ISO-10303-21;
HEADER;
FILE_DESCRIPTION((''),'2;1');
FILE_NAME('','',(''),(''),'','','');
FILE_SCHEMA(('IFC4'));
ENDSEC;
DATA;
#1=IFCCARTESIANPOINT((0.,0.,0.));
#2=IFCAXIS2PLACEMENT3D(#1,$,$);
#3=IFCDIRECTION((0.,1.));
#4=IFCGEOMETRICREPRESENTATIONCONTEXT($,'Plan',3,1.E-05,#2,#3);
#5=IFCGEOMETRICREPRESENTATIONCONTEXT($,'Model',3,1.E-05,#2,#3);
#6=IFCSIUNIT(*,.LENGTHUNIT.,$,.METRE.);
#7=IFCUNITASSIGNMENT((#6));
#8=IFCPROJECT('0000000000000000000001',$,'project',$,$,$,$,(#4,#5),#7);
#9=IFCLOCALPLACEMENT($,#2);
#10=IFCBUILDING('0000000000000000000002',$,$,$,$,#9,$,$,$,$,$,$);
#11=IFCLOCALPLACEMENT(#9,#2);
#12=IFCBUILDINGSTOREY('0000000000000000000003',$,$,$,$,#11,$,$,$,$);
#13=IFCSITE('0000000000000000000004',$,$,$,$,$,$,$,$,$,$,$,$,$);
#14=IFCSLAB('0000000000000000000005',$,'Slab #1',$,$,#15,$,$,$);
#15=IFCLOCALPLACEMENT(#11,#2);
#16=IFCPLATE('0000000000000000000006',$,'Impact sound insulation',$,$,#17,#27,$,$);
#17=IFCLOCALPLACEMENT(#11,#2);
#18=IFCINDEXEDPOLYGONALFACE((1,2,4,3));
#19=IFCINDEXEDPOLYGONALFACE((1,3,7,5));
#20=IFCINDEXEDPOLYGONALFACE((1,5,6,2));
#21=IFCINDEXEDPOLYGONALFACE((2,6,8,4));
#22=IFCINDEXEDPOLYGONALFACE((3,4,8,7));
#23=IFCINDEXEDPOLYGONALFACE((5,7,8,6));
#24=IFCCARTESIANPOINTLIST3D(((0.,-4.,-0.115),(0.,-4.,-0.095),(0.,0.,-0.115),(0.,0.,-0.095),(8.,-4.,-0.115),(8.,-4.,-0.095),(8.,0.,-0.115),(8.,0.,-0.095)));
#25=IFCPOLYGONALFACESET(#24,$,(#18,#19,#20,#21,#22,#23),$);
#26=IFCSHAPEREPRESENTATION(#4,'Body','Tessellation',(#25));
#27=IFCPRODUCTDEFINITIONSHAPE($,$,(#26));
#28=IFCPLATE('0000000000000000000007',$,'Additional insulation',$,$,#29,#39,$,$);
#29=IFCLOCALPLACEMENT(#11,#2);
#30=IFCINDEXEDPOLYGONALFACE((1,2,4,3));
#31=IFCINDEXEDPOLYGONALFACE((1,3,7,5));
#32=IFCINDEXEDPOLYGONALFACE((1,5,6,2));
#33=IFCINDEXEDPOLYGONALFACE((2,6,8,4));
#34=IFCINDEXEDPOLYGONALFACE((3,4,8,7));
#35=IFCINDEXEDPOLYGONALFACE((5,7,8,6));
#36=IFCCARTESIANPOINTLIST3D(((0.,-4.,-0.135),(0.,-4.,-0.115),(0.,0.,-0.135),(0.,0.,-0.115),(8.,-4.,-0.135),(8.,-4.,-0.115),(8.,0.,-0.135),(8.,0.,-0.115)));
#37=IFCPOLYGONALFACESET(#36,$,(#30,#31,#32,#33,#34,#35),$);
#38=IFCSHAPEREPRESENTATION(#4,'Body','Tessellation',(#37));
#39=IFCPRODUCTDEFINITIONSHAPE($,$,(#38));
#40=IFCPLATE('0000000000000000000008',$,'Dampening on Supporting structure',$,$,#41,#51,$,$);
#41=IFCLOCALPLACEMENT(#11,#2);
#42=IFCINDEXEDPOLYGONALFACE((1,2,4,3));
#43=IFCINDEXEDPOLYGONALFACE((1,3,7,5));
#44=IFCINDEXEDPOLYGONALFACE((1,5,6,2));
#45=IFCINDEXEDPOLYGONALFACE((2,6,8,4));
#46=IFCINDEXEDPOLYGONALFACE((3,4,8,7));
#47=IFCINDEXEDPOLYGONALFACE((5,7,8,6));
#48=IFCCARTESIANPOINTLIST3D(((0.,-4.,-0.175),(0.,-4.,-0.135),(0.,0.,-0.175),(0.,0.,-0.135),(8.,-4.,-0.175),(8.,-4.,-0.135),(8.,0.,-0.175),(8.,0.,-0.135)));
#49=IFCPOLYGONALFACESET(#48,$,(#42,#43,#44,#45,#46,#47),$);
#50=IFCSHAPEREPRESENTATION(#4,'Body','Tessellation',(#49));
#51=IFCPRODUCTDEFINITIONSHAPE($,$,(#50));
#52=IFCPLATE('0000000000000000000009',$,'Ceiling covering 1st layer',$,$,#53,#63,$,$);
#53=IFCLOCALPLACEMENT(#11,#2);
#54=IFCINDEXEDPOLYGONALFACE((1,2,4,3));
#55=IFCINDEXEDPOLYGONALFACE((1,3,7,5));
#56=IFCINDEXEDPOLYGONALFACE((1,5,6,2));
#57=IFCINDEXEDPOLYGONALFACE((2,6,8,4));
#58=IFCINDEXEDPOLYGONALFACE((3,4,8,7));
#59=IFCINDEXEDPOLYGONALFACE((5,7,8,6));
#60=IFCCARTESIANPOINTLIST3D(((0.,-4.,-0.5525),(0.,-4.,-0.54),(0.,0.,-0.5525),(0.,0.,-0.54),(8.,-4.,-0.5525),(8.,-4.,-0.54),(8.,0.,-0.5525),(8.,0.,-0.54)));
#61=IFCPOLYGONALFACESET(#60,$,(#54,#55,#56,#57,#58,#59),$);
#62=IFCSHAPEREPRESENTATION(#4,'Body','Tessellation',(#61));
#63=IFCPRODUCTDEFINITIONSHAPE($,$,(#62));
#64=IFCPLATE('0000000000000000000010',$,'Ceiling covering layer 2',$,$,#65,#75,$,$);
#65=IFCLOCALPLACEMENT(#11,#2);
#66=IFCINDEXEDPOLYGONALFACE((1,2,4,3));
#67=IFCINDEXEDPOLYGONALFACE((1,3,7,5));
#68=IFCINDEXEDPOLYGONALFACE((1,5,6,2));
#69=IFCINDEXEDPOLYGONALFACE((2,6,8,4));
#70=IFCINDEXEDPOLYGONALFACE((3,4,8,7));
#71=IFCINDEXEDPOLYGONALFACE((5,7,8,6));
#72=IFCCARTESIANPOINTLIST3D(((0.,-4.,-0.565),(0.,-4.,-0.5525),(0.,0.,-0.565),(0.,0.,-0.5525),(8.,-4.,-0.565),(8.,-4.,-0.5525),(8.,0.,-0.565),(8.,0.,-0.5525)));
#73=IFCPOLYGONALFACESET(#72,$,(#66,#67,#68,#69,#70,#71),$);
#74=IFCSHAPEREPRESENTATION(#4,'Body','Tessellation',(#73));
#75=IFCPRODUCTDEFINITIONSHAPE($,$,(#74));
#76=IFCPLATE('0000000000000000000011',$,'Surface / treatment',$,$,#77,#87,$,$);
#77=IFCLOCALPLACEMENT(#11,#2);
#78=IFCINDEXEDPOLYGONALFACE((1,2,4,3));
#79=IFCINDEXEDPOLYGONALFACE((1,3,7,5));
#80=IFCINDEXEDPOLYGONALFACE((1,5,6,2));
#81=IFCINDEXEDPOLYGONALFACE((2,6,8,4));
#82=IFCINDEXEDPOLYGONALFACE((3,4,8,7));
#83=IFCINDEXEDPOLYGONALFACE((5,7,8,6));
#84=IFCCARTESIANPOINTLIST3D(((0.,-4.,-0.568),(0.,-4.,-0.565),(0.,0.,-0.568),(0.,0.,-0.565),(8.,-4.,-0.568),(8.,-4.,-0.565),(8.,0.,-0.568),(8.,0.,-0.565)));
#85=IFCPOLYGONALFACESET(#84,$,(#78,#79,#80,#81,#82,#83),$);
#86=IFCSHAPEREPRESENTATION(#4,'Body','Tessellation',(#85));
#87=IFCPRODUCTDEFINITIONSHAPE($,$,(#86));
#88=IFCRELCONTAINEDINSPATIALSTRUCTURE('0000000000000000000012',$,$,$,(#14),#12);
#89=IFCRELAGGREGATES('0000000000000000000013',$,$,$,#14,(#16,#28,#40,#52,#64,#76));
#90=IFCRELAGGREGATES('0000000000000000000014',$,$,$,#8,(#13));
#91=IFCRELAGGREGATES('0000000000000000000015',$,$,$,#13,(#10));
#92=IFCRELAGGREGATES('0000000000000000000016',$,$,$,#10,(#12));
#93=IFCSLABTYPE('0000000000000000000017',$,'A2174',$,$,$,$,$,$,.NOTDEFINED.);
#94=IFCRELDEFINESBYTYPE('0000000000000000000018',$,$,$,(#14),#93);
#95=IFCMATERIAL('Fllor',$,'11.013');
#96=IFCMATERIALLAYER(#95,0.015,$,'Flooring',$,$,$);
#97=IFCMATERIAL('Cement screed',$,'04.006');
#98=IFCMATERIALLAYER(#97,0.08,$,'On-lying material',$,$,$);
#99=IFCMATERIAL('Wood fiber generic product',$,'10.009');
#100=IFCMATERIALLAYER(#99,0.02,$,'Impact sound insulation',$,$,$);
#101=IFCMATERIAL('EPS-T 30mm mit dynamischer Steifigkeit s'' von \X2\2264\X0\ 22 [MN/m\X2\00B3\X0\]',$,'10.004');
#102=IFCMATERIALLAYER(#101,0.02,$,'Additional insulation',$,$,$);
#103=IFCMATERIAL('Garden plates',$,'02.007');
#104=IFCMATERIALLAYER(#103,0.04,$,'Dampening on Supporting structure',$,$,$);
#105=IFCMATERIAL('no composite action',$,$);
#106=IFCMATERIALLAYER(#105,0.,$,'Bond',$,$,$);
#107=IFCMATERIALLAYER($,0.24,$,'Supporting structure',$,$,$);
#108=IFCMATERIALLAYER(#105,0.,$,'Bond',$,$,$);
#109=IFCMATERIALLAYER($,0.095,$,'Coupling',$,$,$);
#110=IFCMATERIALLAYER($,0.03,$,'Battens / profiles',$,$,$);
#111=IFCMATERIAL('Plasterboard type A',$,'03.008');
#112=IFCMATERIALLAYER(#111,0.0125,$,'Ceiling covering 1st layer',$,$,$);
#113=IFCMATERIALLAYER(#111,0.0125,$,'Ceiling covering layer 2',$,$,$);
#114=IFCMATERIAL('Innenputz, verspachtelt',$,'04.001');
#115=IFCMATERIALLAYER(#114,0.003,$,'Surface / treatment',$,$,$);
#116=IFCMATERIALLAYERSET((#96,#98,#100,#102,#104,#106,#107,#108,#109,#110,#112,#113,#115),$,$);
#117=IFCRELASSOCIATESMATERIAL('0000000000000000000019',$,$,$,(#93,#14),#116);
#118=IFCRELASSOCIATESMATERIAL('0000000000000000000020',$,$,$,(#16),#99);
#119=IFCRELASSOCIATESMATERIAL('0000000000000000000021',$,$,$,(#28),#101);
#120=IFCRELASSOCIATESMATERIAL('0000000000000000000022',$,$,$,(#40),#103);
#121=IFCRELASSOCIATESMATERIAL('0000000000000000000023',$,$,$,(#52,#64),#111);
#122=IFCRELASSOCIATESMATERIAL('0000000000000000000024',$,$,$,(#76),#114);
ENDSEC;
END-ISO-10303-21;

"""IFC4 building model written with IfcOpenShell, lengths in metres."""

from ifc_helpers import new_model, si_unit, direction, frame, frame_2d, origin, place, context, project, spatial, rectangle, extrude, material, layer, layer_set, type_object, element, aggregate, save


model = new_model("IFC4")

# Units and contexts
plan_context = context("Plan", 3, precision=1e-05, world=origin(), true_north=direction((0.0, 1.0)))
model_context = context("Model", 3, precision=1e-05, world=origin(), true_north=direction((0.0, 1.0)))
ifc_project = project(units=[si_unit("LENGTHUNIT", "METRE")], contexts=[plan_context, model_context])

# Site, building, storey
site = spatial("IfcSite", under=ifc_project)
building_placement = place(None, origin())
building = spatial("IfcBuilding", under=site, at=building_placement)
storey_placement = place(building_placement, origin())
storey = spatial("IfcBuildingStorey", under=building, at=storey_placement)

# Slab, plates
ifc_material_1 = material(Name="Fllor", Category="11.013")
ifc_layer_1 = layer(ifc_material_1, 0.015, Name="Flooring")
ifc_material_2 = material(Name="Cement screed", Category="04.006")
ifc_layer_2 = layer(ifc_material_2, 0.08, Name="On-lying material")
ifc_material_3 = material(Name="Wood fiber generic product", Category="10.009")
ifc_layer_3 = layer(ifc_material_3, 0.02, Name="Impact sound insulation")
ifc_material_4 = material(Name="EPS-T 30mm mit dynamischer Steifigkeit s' von ≤ 22 [MN/m³]", Category="10.004")
ifc_layer_4 = layer(ifc_material_4, 0.02, Name="Additional insulation")
ifc_material_5 = material(Name="Garden plates", Category="02.007")
ifc_layer_5 = layer(ifc_material_5, 0.04, Name="Dampening on Supporting structure")
ifc_material_6 = material(Name="no composite action")
ifc_layer_6 = layer(ifc_material_6, 0.0, Name="Bond")
ifc_layer_7 = layer(None, 0.24, Name="Supporting structure")
ifc_layer_8 = layer(ifc_material_6, 0.0, Name="Bond")
ifc_layer_9 = layer(None, 0.095, Name="Coupling")
ifc_layer_10 = layer(None, 0.03, Name="Battens / profiles")
ifc_material_7 = material(Name="Plasterboard type A", Category="03.008")
ifc_layer_11 = layer(ifc_material_7, 0.0125, Name="Ceiling covering 1st layer")
ifc_layer_12 = layer(ifc_material_7, 0.0125, Name="Ceiling covering layer 2")
ifc_material_8 = material(Name="Innenputz, verspachtelt", Category="04.001")
ifc_layer_13 = layer(ifc_material_8, 0.003, Name="Surface / treatment")
ifc_layer_set = layer_set([ifc_layer_1, ifc_layer_2, ifc_layer_3, ifc_layer_4, ifc_layer_5, ifc_layer_6, ifc_layer_7, ifc_layer_8, ifc_layer_9, ifc_layer_10, ifc_layer_11, ifc_layer_12, ifc_layer_13])
slab_type = type_object("IfcSlabType", Name="A2174", PredefinedType="NOTDEFINED", material=ifc_layer_set)
slab_placement = place(None, frame((0.0, 0.0, 0.0), z_axis=(0.0, 0.0, -1.0), x_axis=(1.0, 0.0, 0.0)))
slab = element("IfcSlab", 1, at=slab_placement, inside=storey, type_object=slab_type, material=ifc_layer_set, Name="Slab #1")
plate_1_placement = place(slab_placement, origin())
plate_1 = element("IfcPlate", 2, at=plate_1_placement, material=ifc_material_3, Name="Impact sound insulation", context=plan_context, shape_type="SweptSolid", body=[
    extrude(rectangle(XDim=8.0, YDim=4.0, at=frame_2d((4.0, 2.0), x_axis=(1.0, 0.0))), frame((0.0, 0.0, 0.095), z_axis=(0.0, 0.0, 1.0), x_axis=(1.0, 0.0, 0.0)), (0.0, 0.0, 1.0), 0.02),
])
plate_2_placement = place(slab_placement, origin())
plate_2 = element("IfcPlate", 3, at=plate_2_placement, material=ifc_material_4, Name="Additional insulation", context=plan_context, shape_type="SweptSolid", body=[
    extrude(rectangle(XDim=8.0, YDim=4.0, at=frame_2d((4.0, 2.0), x_axis=(1.0, 0.0))), frame((0.0, 0.0, 0.115), z_axis=(0.0, 0.0, 1.0), x_axis=(1.0, 0.0, 0.0)), (0.0, 0.0, 1.0), 0.02),
])
plate_3_placement = place(slab_placement, origin())
plate_3 = element("IfcPlate", 4, at=plate_3_placement, material=ifc_material_5, Name="Dampening on Supporting structure", context=plan_context, shape_type="SweptSolid", body=[
    extrude(rectangle(XDim=8.0, YDim=4.0, at=frame_2d((4.0, 2.0), x_axis=(1.0, 0.0))), frame((0.0, 0.0, 0.135), z_axis=(0.0, 0.0, 1.0), x_axis=(1.0, 0.0, 0.0)), (0.0, 0.0, 1.0), 0.04),
])
plate_4_placement = place(slab_placement, origin())
plate_4 = element("IfcPlate", 5, at=plate_4_placement, material=ifc_material_7, Name="Ceiling covering 1st layer", context=plan_context, shape_type="SweptSolid", body=[
    extrude(rectangle(XDim=8.0, YDim=4.0, at=frame_2d((4.0, 2.0), x_axis=(1.0, 0.0))), frame((0.0, 0.0, 0.54), z_axis=(0.0, 0.0, 1.0), x_axis=(1.0, 0.0, 0.0)), (0.0, 0.0, 1.0), 0.0125),
])
plate_5_placement = place(slab_placement, origin())
plate_5 = element("IfcPlate", 6, at=plate_5_placement, material=ifc_material_7, Name="Ceiling covering layer 2", context=plan_context, shape_type="SweptSolid", body=[
    extrude(rectangle(XDim=8.0, YDim=4.0, at=frame_2d((4.0, 2.0), x_axis=(1.0, 0.0))), frame((0.0, 0.0, 0.5525), z_axis=(0.0, 0.0, 1.0), x_axis=(1.0, 0.0, 0.0)), (0.0, 0.0, 1.0), 0.0125),
])
plate_6_placement = place(slab_placement, origin())
plate_6 = element("IfcPlate", 7, at=plate_6_placement, material=ifc_material_8, Name="Surface / treatment", context=plan_context, shape_type="SweptSolid", body=[
    extrude(rectangle(XDim=8.0, YDim=4.0, at=frame_2d((4.0, 2.0), x_axis=(1.0, 0.0))), frame((0.0, 0.0, 0.565), z_axis=(0.0, 0.0, 1.0), x_axis=(1.0, 0.0, 0.0)), (0.0, 0.0, 1.0), 0.003),
])
aggregate(slab, [plate_1, plate_2, plate_3, plate_4, plate_5, plate_6])

save(model, "model.ifc")
